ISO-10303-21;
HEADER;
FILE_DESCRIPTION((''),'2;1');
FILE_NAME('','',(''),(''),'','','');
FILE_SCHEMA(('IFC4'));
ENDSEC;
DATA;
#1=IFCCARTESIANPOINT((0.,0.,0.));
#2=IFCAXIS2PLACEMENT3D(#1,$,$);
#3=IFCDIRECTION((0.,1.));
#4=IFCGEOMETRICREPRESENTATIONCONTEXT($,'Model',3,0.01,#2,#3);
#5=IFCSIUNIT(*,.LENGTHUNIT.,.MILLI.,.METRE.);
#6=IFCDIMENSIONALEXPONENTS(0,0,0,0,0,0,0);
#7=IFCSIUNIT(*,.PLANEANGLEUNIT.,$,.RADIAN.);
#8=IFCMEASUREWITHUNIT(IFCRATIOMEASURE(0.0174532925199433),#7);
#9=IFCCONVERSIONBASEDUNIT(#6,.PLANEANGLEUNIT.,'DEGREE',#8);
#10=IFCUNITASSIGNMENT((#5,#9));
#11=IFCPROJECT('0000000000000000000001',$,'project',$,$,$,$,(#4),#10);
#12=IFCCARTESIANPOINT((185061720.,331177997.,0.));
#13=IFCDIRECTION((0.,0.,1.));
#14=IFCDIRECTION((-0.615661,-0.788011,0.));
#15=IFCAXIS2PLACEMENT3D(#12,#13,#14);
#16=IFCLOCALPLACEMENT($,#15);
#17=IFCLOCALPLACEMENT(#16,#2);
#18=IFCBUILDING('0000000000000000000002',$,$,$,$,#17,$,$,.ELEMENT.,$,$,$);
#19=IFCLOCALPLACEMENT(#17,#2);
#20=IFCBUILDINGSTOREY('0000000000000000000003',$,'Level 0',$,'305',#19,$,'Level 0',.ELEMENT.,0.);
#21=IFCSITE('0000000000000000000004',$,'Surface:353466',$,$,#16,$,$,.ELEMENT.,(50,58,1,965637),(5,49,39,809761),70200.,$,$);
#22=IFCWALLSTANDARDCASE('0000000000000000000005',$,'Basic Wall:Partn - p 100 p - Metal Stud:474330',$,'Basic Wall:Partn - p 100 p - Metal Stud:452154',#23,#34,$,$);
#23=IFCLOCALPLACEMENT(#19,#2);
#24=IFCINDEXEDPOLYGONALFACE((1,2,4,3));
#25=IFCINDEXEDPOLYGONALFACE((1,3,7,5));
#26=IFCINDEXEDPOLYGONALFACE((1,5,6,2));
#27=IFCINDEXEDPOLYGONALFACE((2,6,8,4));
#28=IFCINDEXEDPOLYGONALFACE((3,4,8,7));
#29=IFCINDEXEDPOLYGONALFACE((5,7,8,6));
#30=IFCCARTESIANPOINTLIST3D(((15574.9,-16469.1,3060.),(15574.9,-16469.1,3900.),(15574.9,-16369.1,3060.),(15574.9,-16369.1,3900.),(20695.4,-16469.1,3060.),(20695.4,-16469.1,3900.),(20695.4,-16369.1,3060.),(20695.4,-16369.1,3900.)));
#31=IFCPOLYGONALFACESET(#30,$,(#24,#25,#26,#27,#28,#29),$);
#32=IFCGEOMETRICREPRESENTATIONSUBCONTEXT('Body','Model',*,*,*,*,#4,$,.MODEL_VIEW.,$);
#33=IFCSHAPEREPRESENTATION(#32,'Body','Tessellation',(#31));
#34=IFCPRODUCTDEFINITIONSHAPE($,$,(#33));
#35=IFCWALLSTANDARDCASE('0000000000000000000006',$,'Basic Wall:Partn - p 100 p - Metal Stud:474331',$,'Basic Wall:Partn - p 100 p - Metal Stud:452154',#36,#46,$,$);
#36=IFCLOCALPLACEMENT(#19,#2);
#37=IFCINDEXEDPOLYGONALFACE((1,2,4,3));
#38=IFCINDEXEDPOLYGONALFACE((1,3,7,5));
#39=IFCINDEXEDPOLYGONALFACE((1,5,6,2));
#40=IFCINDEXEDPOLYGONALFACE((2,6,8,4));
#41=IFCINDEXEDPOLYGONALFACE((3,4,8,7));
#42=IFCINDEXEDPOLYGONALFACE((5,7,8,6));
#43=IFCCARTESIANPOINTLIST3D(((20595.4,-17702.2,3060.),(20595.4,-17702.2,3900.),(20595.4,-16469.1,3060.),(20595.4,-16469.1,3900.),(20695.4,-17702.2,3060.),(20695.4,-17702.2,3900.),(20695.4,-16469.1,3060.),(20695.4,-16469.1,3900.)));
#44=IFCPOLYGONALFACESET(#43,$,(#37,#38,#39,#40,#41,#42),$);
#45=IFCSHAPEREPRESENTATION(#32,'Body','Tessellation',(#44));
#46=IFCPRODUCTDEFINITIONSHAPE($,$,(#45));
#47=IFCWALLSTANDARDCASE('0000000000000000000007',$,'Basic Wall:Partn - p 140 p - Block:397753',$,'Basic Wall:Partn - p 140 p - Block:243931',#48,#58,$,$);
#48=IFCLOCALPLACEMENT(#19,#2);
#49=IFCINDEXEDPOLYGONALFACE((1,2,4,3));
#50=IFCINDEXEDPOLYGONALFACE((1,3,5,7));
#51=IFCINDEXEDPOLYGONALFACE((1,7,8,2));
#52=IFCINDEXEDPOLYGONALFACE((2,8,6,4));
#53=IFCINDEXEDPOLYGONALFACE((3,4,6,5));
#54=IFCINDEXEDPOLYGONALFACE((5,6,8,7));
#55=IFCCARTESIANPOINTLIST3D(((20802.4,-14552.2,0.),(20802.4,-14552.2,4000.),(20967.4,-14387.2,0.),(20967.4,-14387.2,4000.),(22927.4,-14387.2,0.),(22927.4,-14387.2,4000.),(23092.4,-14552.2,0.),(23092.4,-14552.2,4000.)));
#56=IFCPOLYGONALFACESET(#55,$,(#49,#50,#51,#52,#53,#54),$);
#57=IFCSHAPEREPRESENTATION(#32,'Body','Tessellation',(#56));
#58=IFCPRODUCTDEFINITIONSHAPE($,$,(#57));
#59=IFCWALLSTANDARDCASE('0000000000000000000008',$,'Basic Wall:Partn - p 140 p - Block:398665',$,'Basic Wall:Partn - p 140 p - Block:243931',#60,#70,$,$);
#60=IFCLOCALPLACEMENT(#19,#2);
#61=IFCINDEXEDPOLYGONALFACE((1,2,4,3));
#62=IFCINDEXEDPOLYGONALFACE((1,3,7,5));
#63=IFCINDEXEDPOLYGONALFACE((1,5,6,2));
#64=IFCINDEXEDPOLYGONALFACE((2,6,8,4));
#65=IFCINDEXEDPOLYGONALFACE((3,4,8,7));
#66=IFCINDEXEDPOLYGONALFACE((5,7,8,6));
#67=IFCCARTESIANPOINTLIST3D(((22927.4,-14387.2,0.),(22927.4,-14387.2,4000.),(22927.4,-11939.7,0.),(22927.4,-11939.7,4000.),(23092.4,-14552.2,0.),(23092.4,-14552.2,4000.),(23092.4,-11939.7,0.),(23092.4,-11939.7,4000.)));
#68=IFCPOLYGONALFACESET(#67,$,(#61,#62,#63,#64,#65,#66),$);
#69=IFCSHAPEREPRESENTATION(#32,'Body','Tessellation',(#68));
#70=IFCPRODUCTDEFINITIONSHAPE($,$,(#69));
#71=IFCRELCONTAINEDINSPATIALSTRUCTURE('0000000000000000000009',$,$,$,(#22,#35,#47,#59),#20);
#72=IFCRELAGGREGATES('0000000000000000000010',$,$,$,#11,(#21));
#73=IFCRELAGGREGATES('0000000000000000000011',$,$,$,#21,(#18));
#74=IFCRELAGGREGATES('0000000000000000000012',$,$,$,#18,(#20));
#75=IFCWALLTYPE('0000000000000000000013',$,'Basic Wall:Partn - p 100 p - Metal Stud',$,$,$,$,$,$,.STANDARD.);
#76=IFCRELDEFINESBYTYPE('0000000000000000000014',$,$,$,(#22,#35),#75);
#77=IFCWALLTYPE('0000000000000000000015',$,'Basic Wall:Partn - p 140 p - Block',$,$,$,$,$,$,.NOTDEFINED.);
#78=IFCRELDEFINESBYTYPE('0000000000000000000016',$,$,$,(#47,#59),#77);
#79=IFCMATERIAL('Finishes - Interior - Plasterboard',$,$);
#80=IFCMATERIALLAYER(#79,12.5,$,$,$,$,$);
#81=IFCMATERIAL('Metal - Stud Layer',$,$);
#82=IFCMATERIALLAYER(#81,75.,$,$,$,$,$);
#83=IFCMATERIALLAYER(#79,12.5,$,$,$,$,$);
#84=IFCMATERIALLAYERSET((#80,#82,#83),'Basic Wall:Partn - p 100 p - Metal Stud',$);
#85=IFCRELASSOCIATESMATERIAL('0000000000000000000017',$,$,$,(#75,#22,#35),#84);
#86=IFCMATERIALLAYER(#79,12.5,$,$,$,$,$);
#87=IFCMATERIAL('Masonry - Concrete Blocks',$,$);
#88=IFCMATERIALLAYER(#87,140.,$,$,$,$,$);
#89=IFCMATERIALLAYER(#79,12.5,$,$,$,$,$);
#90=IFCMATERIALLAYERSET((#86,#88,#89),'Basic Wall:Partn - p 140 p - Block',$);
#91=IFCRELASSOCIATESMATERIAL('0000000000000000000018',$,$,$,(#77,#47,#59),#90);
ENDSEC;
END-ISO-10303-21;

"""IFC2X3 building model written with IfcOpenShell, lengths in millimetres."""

from ifc_helpers import new_model, entity, si_unit, converted_unit, direction, frame, frame_2d, origin, place, context, subcontext, project, spatial, polyline, rectangle, outline, extrude, clip, halfspace, material, layer, layer_set, layer_usage, type_object, element, save


model = new_model("IFC2X3")

# Units and contexts
model_context = context("Model", 3, precision=0.01, world=origin(), true_north=direction((0.0, 1.0)))
body_context = subcontext(model_context, "Body", "Model", "MODEL_VIEW")
ifc_project = project(units=[si_unit("LENGTHUNIT", "METRE", prefix="MILLI"), converted_unit("PLANEANGLEUNIT", "DEGREE", entity("IfcRatioMeasure", 0.0174532925199433), si_unit("PLANEANGLEUNIT", "RADIAN"), dimensions=[0, 0, 0, 0, 0, 0, 0])], contexts=[model_context])

# Site, building, storey
site_placement = place(None, frame((185061720.0, 331177997.0, 0.0), z_axis=(0.0, 0.0, 1.0), x_axis=(-0.615661, -0.788011, 0.0)))
site = spatial("IfcSite", under=ifc_project, at=site_placement, Name="Surface:353466", CompositionType="ELEMENT", RefLatitude=(50, 58, 1, 965637), RefLongitude=(5, 49, 39, 809761), RefElevation=70200.0)
building_placement = place(site_placement, origin())
building = spatial("IfcBuilding", under=site, at=building_placement, CompositionType="ELEMENT")
storey_placement = place(building_placement, origin())
storey = spatial("IfcBuildingStorey", under=building, at=storey_placement, Name="Level 0", ObjectType="305", LongName="Level 0", CompositionType="ELEMENT", Elevation=0.0)

# Shared definitions
ifc_material_1 = material(Name="Masonry - Concrete Blocks")
ifc_material_2 = material(Name="Finishes - Interior - Plasterboard")

# Walls
ifc_layer_1 = layer(ifc_material_2, 12.5)
ifc_material_3 = material(Name="Metal - Stud Layer")
ifc_layer_2 = layer(ifc_material_3, 75.0)
ifc_layer_3 = layer(ifc_material_2, 12.5)
ifc_layer_set_1 = layer_set([ifc_layer_1, ifc_layer_2, ifc_layer_3], Name="Basic Wall:Partn - p 100 p - Metal Stud")
wall_type_1 = type_object("IfcWallType", Name="Basic Wall:Partn - p 100 p - Metal Stud", PredefinedType="STANDARD", material=ifc_layer_set_1)
ifc_layer_usage_1 = layer_usage(ifc_layer_set_1, "AXIS2", "POSITIVE", -50.0)
wall_1_placement = place(storey_placement, frame((20695.4, -16419.1, 3060.0), z_axis=(0.0, 0.0, 1.0), x_axis=(-1.0, 0.0, 0.0)))
element("IfcWallStandardCase", 1, at=wall_1_placement, inside=storey, type_object=wall_type_1, material=ifc_layer_usage_1, Name="Basic Wall:Partn - p 100 p - Metal Stud:474330", ObjectType="Basic Wall:Partn - p 100 p - Metal Stud:452154", context=body_context, shape_type="SweptSolid", body=[
    extrude(rectangle(XDim=5120.5, YDim=100.0, at=frame_2d((2560.3, 0.0), x_axis=(-1.0, 0.0))), origin(), (0.0, 0.0, 1.0), 840.0),
])
ifc_layer_usage_2 = layer_usage(ifc_layer_set_1, "AXIS2", "POSITIVE", -50.0)
wall_2_placement = place(storey_placement, frame((20645.4, -17702.2, 3060.0), z_axis=(0.0, 0.0, 1.0), x_axis=(0.0, 1.0, 0.0)))
element("IfcWallStandardCase", 2, at=wall_2_placement, inside=storey, type_object=wall_type_1, material=ifc_layer_usage_2, Name="Basic Wall:Partn - p 100 p - Metal Stud:474331", ObjectType="Basic Wall:Partn - p 100 p - Metal Stud:452154", context=body_context, shape_type="SweptSolid", body=[
    extrude(rectangle(XDim=1233.1, YDim=100.0, at=frame_2d((616.6, 0.0), x_axis=(-1.0, 0.0))), origin(), (0.0, 0.0, 1.0), 840.0),
])

# Walls
ifc_layer_4 = layer(ifc_material_2, 12.5)
ifc_layer_5 = layer(ifc_material_1, 140.0)
ifc_layer_6 = layer(ifc_material_2, 12.5)
ifc_layer_set_2 = layer_set([ifc_layer_4, ifc_layer_5, ifc_layer_6], Name="Basic Wall:Partn - p 140 p - Block")
ifc_layer_usage_3 = layer_usage(ifc_layer_set_2, "AXIS2", "NEGATIVE", 82.5)
wall_type_2 = type_object("IfcWallType", Name="Basic Wall:Partn - p 140 p - Block", PredefinedType="NOTDEFINED", material=ifc_layer_set_2)
wall_3_placement = place(storey_placement, frame((23092.4, -14469.7, 0.0), z_axis=(0.0, 0.0, 1.0), x_axis=(-1.0, 0.0, 0.0)))
element("IfcWallStandardCase", 3, at=wall_3_placement, inside=storey, type_object=wall_type_2, material=ifc_layer_usage_3, Name="Basic Wall:Partn - p 140 p - Block:397753", ObjectType="Basic Wall:Partn - p 140 p - Block:243931", context=body_context, shape_type="Clipping", body=[
    clip(extrude(outline(polyline([(2125.0, -82.5), (2290.0, 82.5), (0.0, 82.5), (165.0, -82.5), (2125.0, -82.5)])), origin(), (0.0, 0.0, 1.0), 4000.0), halfspace(origin(), True)),
])
ifc_layer_usage_4 = layer_usage(ifc_layer_set_2, "AXIS2", "NEGATIVE", 82.5)
wall_4_placement = place(storey_placement, frame((23009.9, -14552.2, 0.0), z_axis=(0.0, 0.0, 1.0), x_axis=(0.0, 1.0, 0.0)))
element("IfcWallStandardCase", 4, at=wall_4_placement, inside=storey, type_object=wall_type_2, material=ifc_layer_usage_4, Name="Basic Wall:Partn - p 140 p - Block:398665", ObjectType="Basic Wall:Partn - p 140 p - Block:243931", context=body_context, shape_type="Clipping", body=[
    clip(extrude(outline(polyline([(2612.5, -82.5), (2612.5, 82.5), (165.0, 82.5), (0.0, -82.5), (2612.5, -82.5)])), origin(), (0.0, 0.0, 1.0), 4000.0), halfspace(origin(), True)),
])

save(model, "model.ifc")
